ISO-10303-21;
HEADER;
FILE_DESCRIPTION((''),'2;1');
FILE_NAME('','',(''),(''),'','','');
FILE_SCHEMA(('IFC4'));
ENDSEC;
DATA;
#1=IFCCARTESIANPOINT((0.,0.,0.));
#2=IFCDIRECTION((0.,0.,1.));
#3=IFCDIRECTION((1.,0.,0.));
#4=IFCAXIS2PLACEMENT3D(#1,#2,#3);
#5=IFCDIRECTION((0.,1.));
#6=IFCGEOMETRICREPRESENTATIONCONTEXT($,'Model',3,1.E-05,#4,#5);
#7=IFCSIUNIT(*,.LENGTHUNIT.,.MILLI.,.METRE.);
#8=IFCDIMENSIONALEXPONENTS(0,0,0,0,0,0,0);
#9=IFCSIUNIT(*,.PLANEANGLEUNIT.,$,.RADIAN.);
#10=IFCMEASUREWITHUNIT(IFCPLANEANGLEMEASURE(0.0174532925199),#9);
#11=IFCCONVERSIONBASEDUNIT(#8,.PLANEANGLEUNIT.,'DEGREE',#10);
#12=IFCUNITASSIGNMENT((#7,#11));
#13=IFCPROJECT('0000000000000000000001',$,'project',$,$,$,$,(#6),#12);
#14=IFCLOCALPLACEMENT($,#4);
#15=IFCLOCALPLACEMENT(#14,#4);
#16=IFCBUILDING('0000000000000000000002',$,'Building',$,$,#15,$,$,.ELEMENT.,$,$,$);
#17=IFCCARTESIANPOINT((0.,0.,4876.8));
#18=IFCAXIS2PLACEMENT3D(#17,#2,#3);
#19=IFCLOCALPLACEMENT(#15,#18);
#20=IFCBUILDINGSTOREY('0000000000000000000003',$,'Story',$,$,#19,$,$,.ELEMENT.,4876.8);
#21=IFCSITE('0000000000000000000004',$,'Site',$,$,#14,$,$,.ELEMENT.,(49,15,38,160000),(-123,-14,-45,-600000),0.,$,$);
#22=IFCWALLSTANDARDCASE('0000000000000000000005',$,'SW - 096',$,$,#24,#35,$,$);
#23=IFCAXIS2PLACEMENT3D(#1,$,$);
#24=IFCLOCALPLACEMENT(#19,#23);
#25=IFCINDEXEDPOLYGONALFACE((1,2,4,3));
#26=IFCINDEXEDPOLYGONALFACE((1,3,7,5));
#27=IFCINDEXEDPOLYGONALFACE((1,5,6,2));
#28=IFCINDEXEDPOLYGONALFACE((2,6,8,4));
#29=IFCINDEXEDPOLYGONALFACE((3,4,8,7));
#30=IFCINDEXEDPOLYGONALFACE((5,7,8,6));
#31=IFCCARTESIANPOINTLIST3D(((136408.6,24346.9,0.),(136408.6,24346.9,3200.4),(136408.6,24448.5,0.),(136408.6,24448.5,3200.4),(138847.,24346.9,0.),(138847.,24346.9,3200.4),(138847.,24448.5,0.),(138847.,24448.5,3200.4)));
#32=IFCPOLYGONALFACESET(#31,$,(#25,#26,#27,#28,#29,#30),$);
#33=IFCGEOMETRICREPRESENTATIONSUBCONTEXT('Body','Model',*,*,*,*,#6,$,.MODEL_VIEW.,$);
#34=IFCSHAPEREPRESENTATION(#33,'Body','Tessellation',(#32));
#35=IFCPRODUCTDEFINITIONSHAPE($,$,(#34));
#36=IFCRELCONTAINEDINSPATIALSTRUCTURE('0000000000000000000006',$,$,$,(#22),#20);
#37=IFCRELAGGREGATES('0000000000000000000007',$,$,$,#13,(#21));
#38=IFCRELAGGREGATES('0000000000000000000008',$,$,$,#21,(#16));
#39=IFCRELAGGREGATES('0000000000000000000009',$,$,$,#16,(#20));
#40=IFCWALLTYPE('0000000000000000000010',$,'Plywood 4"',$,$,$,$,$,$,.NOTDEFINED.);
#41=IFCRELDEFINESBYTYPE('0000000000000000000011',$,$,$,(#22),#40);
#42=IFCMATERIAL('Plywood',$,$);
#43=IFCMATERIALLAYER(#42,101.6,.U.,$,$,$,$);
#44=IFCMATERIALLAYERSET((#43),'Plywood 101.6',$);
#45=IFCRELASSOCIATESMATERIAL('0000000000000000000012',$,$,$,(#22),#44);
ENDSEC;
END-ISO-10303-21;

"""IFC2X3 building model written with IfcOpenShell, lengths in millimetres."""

from ifc_helpers import new_model, entity, si_unit, converted_unit, direction, frame, origin_with_axes, place, context, subcontext, project, spatial, polyline, outline, extrude, material, layer, layer_set, layer_usage, type_object, element, save


model = new_model("IFC2X3")

# Units and contexts
model_context = context("Model", 3, precision=1e-05, world=origin_with_axes(), true_north=direction((0.0, 1.0)))
body_context = subcontext(model_context, "Body", "Model", "MODEL_VIEW")
ifc_project = project(units=[si_unit("LENGTHUNIT", "METRE", prefix="MILLI"), converted_unit("PLANEANGLEUNIT", "DEGREE", entity("IfcPlaneAngleMeasure", 0.0174532925199), si_unit("PLANEANGLEUNIT", "RADIAN"), dimensions=[0, 0, 0, 0, 0, 0, 0])], contexts=[model_context])

# Site, building, storey
site_placement = place(None, origin_with_axes())
site = spatial("IfcSite", under=ifc_project, at=site_placement, Name="Site", CompositionType="ELEMENT", RefLatitude=(49, 15, 38, 160000), RefLongitude=(-123, -14, -45, -600000), RefElevation=0.0)
building_placement = place(site_placement, origin_with_axes())
building = spatial("IfcBuilding", under=site, at=building_placement, Name="Building", CompositionType="ELEMENT")
storey_placement = place(building_placement, frame((0.0, 0.0, 4876.8), z_axis=(0.0, 0.0, 1.0), x_axis=(1.0, 0.0, 0.0)))
storey = spatial("IfcBuildingStorey", under=building, at=storey_placement, Name="Story", CompositionType="ELEMENT", Elevation=4876.8)

# Shared definitions
ifc_material_1 = material(Name="Plywood")

# Shared definitions
ifc_layer_1 = layer(ifc_material_1, 101.6, ventilated="UNKNOWN")
ifc_layer_set_1 = layer_set([ifc_layer_1], Name="Plywood 101.6")
wall_type_1 = type_object("IfcWallType", Name="Plywood 4\"", PredefinedType="NOTDEFINED")

# Wall
ifc_layer_usage_1 = layer_usage(ifc_layer_set_1, "AXIS2", "NEGATIVE", 0.0)
wall_1_placement = place(storey_placement, frame((136408.6, 24448.5, 0.0), z_axis=(0.0, 0.0, 1.0), x_axis=(1.0, 0.0, 0.0)))
element("IfcWallStandardCase", 1, at=wall_1_placement, inside=storey, type_object=wall_type_1, material=ifc_layer_usage_1, Name="SW - 096", context=body_context, shape_type="SweptSolid", body=[
    extrude(outline(polyline([(0.0, -101.6), (2438.4, -101.6), (2438.4, 0.0), (0.0, 0.0), (0.0, -101.6)])), origin_with_axes(), (0.0, 0.0, 1.0), 3200.4),
])

save(model, "model.ifc")
